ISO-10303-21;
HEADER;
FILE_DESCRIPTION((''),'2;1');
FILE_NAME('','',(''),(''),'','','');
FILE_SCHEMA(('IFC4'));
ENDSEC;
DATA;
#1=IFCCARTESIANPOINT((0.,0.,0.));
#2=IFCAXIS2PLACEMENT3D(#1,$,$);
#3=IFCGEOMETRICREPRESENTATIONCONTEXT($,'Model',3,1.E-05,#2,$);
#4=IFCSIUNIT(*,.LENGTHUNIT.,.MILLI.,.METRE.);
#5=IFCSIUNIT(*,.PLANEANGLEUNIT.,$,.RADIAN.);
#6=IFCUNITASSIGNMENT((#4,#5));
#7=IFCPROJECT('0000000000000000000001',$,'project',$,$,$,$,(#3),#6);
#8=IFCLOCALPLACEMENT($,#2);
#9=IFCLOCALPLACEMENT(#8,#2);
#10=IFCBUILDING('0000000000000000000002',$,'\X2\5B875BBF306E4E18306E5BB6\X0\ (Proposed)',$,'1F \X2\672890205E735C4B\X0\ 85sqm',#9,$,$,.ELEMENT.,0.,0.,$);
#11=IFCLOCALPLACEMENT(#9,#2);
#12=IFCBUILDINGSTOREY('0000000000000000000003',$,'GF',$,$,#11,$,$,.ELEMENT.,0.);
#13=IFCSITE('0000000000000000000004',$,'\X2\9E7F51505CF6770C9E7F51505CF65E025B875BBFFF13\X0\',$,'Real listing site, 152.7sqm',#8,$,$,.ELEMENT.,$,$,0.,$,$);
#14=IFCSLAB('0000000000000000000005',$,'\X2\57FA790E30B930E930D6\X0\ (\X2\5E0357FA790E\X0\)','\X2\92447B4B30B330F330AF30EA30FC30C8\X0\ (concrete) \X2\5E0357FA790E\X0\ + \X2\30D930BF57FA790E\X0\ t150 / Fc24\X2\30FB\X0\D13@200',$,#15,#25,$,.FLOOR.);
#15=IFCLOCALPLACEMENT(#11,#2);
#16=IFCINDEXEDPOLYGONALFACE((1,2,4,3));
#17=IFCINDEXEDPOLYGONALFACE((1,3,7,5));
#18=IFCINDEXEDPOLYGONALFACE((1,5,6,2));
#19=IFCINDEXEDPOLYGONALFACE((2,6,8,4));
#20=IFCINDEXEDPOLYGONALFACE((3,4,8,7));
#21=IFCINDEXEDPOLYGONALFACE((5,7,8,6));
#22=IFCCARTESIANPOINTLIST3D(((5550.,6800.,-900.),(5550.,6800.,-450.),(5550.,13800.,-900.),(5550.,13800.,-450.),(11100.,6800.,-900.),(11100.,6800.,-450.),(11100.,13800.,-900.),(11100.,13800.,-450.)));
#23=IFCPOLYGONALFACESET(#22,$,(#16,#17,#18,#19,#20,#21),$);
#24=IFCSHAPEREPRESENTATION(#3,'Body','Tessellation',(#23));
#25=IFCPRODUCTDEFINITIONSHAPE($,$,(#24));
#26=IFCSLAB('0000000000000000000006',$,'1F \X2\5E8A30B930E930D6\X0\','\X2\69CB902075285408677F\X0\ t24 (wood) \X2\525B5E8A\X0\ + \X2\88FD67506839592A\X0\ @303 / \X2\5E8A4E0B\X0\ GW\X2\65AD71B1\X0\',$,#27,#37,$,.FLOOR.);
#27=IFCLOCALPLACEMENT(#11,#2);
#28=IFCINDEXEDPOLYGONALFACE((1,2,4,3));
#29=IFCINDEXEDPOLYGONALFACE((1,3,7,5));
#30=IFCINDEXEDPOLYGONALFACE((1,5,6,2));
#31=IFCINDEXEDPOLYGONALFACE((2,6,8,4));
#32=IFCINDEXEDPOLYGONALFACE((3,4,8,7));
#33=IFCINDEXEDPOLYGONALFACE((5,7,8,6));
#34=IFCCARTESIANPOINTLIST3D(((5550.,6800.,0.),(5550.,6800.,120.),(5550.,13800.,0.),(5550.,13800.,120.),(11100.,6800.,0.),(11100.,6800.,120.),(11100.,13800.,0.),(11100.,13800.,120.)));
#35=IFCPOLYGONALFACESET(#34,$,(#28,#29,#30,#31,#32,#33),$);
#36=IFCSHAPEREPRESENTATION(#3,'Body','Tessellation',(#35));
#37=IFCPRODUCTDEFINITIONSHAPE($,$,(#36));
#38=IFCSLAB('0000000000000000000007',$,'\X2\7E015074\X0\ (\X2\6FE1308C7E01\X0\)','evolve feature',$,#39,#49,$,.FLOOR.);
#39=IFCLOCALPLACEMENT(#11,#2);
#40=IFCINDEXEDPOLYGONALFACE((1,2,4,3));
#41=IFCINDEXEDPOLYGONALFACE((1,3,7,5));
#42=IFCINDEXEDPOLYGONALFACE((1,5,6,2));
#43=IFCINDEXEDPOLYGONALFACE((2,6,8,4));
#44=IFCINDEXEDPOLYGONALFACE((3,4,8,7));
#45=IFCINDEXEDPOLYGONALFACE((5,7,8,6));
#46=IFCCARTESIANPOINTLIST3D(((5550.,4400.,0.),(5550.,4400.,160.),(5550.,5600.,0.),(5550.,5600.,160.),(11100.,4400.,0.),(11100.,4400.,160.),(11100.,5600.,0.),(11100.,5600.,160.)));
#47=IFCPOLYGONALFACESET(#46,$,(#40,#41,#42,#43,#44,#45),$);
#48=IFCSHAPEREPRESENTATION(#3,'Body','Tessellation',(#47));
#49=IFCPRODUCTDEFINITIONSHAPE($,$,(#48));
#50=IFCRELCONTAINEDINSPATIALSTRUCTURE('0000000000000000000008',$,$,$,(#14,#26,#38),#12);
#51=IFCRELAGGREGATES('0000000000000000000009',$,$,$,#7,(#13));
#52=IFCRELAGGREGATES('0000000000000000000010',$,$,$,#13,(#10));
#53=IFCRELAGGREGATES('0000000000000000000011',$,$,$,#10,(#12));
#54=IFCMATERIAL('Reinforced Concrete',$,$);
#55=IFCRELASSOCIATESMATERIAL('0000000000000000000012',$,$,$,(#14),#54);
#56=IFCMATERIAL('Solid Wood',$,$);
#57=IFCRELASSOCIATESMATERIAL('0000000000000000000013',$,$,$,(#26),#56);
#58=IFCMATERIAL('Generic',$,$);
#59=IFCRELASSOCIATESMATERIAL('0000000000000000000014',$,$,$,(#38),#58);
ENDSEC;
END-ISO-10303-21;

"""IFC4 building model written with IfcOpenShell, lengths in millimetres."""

from ifc_helpers import new_model, si_unit, frame, frame_2d, origin, place, context, project, spatial, rectangle, extrude, material, element, save


model = new_model("IFC4")

# Units and contexts
model_context = context("Model", 3, precision=1e-05, world=origin())
ifc_project = project(units=[si_unit("LENGTHUNIT", "METRE", prefix="MILLI"), si_unit("PLANEANGLEUNIT", "RADIAN")], contexts=[model_context])

# Site, building, storey
site_placement = place(None, origin())
site = spatial("IfcSite", under=ifc_project, at=site_placement, Name="鹿児島県鹿児島市宇宿３", ObjectType="Real listing site, 152.7sqm", CompositionType="ELEMENT", RefElevation=0.0)
building_placement = place(site_placement, origin())
building = spatial("IfcBuilding", under=site, at=building_placement, Name="宇宿の丘の家 (Proposed)", ObjectType="1F 木造平屋 85sqm", CompositionType="ELEMENT", ElevationOfRefHeight=0.0, ElevationOfTerrain=0.0)
storey_placement = place(building_placement, origin())
storey = spatial("IfcBuildingStorey", under=building, at=storey_placement, Name="GF", CompositionType="ELEMENT", Elevation=0.0)

# Slabs
ifc_material_1 = material(Name="Reinforced Concrete")
slab_1_placement = place(storey_placement, frame((2775.0, 3400.0, -450.0)))
element("IfcSlab", 1, at=slab_1_placement, inside=storey, material=ifc_material_1, Name="基礎スラブ (布基礎)", Description="鉄筋コンクリート (concrete) 布基礎 + ベタ基礎 t150 / Fc24・D13@200", PredefinedType="FLOOR", context=model_context, shape_type="SweptSolid", body=[
    extrude(rectangle(XDim=5550.0, YDim=7000.0, at=frame_2d((2775.0, 3500.0))), frame((2775.0, 3400.0, -450.0)), (0.0, 0.0, 1.0), 450.0),
])
ifc_material_2 = material(Name="Solid Wood")
slab_2_placement = place(storey_placement, frame((2775.0, 3400.0, 0.0)))
element("IfcSlab", 2, at=slab_2_placement, inside=storey, material=ifc_material_2, Name="1F 床スラブ", Description="構造用合板 t24 (wood) 剛床 + 製材根太 @303 / 床下 GW断熱", PredefinedType="FLOOR", context=model_context, shape_type="SweptSolid", body=[
    extrude(rectangle(XDim=5550.0, YDim=7000.0, at=frame_2d((2775.0, 3500.0))), frame((2775.0, 3400.0, 0.0)), (0.0, 0.0, 1.0), 120.0),
])
ifc_material_3 = material(Name="Generic")
slab_3_placement = place(storey_placement, frame((2775.0, 2200.0, 0.0)))
element("IfcSlab", 3, at=slab_3_placement, inside=storey, material=ifc_material_3, Name="縁側 (濡れ縁)", Description="evolve feature", PredefinedType="FLOOR", context=model_context, shape_type="SweptSolid", body=[
    extrude(rectangle(XDim=5550.0, YDim=1200.0, at=frame_2d((2775.0, 600.0))), frame((2775.0, 2200.0, 0.0)), (0.0, 0.0, 1.0), 160.0),
])

save(model, "model.ifc")
